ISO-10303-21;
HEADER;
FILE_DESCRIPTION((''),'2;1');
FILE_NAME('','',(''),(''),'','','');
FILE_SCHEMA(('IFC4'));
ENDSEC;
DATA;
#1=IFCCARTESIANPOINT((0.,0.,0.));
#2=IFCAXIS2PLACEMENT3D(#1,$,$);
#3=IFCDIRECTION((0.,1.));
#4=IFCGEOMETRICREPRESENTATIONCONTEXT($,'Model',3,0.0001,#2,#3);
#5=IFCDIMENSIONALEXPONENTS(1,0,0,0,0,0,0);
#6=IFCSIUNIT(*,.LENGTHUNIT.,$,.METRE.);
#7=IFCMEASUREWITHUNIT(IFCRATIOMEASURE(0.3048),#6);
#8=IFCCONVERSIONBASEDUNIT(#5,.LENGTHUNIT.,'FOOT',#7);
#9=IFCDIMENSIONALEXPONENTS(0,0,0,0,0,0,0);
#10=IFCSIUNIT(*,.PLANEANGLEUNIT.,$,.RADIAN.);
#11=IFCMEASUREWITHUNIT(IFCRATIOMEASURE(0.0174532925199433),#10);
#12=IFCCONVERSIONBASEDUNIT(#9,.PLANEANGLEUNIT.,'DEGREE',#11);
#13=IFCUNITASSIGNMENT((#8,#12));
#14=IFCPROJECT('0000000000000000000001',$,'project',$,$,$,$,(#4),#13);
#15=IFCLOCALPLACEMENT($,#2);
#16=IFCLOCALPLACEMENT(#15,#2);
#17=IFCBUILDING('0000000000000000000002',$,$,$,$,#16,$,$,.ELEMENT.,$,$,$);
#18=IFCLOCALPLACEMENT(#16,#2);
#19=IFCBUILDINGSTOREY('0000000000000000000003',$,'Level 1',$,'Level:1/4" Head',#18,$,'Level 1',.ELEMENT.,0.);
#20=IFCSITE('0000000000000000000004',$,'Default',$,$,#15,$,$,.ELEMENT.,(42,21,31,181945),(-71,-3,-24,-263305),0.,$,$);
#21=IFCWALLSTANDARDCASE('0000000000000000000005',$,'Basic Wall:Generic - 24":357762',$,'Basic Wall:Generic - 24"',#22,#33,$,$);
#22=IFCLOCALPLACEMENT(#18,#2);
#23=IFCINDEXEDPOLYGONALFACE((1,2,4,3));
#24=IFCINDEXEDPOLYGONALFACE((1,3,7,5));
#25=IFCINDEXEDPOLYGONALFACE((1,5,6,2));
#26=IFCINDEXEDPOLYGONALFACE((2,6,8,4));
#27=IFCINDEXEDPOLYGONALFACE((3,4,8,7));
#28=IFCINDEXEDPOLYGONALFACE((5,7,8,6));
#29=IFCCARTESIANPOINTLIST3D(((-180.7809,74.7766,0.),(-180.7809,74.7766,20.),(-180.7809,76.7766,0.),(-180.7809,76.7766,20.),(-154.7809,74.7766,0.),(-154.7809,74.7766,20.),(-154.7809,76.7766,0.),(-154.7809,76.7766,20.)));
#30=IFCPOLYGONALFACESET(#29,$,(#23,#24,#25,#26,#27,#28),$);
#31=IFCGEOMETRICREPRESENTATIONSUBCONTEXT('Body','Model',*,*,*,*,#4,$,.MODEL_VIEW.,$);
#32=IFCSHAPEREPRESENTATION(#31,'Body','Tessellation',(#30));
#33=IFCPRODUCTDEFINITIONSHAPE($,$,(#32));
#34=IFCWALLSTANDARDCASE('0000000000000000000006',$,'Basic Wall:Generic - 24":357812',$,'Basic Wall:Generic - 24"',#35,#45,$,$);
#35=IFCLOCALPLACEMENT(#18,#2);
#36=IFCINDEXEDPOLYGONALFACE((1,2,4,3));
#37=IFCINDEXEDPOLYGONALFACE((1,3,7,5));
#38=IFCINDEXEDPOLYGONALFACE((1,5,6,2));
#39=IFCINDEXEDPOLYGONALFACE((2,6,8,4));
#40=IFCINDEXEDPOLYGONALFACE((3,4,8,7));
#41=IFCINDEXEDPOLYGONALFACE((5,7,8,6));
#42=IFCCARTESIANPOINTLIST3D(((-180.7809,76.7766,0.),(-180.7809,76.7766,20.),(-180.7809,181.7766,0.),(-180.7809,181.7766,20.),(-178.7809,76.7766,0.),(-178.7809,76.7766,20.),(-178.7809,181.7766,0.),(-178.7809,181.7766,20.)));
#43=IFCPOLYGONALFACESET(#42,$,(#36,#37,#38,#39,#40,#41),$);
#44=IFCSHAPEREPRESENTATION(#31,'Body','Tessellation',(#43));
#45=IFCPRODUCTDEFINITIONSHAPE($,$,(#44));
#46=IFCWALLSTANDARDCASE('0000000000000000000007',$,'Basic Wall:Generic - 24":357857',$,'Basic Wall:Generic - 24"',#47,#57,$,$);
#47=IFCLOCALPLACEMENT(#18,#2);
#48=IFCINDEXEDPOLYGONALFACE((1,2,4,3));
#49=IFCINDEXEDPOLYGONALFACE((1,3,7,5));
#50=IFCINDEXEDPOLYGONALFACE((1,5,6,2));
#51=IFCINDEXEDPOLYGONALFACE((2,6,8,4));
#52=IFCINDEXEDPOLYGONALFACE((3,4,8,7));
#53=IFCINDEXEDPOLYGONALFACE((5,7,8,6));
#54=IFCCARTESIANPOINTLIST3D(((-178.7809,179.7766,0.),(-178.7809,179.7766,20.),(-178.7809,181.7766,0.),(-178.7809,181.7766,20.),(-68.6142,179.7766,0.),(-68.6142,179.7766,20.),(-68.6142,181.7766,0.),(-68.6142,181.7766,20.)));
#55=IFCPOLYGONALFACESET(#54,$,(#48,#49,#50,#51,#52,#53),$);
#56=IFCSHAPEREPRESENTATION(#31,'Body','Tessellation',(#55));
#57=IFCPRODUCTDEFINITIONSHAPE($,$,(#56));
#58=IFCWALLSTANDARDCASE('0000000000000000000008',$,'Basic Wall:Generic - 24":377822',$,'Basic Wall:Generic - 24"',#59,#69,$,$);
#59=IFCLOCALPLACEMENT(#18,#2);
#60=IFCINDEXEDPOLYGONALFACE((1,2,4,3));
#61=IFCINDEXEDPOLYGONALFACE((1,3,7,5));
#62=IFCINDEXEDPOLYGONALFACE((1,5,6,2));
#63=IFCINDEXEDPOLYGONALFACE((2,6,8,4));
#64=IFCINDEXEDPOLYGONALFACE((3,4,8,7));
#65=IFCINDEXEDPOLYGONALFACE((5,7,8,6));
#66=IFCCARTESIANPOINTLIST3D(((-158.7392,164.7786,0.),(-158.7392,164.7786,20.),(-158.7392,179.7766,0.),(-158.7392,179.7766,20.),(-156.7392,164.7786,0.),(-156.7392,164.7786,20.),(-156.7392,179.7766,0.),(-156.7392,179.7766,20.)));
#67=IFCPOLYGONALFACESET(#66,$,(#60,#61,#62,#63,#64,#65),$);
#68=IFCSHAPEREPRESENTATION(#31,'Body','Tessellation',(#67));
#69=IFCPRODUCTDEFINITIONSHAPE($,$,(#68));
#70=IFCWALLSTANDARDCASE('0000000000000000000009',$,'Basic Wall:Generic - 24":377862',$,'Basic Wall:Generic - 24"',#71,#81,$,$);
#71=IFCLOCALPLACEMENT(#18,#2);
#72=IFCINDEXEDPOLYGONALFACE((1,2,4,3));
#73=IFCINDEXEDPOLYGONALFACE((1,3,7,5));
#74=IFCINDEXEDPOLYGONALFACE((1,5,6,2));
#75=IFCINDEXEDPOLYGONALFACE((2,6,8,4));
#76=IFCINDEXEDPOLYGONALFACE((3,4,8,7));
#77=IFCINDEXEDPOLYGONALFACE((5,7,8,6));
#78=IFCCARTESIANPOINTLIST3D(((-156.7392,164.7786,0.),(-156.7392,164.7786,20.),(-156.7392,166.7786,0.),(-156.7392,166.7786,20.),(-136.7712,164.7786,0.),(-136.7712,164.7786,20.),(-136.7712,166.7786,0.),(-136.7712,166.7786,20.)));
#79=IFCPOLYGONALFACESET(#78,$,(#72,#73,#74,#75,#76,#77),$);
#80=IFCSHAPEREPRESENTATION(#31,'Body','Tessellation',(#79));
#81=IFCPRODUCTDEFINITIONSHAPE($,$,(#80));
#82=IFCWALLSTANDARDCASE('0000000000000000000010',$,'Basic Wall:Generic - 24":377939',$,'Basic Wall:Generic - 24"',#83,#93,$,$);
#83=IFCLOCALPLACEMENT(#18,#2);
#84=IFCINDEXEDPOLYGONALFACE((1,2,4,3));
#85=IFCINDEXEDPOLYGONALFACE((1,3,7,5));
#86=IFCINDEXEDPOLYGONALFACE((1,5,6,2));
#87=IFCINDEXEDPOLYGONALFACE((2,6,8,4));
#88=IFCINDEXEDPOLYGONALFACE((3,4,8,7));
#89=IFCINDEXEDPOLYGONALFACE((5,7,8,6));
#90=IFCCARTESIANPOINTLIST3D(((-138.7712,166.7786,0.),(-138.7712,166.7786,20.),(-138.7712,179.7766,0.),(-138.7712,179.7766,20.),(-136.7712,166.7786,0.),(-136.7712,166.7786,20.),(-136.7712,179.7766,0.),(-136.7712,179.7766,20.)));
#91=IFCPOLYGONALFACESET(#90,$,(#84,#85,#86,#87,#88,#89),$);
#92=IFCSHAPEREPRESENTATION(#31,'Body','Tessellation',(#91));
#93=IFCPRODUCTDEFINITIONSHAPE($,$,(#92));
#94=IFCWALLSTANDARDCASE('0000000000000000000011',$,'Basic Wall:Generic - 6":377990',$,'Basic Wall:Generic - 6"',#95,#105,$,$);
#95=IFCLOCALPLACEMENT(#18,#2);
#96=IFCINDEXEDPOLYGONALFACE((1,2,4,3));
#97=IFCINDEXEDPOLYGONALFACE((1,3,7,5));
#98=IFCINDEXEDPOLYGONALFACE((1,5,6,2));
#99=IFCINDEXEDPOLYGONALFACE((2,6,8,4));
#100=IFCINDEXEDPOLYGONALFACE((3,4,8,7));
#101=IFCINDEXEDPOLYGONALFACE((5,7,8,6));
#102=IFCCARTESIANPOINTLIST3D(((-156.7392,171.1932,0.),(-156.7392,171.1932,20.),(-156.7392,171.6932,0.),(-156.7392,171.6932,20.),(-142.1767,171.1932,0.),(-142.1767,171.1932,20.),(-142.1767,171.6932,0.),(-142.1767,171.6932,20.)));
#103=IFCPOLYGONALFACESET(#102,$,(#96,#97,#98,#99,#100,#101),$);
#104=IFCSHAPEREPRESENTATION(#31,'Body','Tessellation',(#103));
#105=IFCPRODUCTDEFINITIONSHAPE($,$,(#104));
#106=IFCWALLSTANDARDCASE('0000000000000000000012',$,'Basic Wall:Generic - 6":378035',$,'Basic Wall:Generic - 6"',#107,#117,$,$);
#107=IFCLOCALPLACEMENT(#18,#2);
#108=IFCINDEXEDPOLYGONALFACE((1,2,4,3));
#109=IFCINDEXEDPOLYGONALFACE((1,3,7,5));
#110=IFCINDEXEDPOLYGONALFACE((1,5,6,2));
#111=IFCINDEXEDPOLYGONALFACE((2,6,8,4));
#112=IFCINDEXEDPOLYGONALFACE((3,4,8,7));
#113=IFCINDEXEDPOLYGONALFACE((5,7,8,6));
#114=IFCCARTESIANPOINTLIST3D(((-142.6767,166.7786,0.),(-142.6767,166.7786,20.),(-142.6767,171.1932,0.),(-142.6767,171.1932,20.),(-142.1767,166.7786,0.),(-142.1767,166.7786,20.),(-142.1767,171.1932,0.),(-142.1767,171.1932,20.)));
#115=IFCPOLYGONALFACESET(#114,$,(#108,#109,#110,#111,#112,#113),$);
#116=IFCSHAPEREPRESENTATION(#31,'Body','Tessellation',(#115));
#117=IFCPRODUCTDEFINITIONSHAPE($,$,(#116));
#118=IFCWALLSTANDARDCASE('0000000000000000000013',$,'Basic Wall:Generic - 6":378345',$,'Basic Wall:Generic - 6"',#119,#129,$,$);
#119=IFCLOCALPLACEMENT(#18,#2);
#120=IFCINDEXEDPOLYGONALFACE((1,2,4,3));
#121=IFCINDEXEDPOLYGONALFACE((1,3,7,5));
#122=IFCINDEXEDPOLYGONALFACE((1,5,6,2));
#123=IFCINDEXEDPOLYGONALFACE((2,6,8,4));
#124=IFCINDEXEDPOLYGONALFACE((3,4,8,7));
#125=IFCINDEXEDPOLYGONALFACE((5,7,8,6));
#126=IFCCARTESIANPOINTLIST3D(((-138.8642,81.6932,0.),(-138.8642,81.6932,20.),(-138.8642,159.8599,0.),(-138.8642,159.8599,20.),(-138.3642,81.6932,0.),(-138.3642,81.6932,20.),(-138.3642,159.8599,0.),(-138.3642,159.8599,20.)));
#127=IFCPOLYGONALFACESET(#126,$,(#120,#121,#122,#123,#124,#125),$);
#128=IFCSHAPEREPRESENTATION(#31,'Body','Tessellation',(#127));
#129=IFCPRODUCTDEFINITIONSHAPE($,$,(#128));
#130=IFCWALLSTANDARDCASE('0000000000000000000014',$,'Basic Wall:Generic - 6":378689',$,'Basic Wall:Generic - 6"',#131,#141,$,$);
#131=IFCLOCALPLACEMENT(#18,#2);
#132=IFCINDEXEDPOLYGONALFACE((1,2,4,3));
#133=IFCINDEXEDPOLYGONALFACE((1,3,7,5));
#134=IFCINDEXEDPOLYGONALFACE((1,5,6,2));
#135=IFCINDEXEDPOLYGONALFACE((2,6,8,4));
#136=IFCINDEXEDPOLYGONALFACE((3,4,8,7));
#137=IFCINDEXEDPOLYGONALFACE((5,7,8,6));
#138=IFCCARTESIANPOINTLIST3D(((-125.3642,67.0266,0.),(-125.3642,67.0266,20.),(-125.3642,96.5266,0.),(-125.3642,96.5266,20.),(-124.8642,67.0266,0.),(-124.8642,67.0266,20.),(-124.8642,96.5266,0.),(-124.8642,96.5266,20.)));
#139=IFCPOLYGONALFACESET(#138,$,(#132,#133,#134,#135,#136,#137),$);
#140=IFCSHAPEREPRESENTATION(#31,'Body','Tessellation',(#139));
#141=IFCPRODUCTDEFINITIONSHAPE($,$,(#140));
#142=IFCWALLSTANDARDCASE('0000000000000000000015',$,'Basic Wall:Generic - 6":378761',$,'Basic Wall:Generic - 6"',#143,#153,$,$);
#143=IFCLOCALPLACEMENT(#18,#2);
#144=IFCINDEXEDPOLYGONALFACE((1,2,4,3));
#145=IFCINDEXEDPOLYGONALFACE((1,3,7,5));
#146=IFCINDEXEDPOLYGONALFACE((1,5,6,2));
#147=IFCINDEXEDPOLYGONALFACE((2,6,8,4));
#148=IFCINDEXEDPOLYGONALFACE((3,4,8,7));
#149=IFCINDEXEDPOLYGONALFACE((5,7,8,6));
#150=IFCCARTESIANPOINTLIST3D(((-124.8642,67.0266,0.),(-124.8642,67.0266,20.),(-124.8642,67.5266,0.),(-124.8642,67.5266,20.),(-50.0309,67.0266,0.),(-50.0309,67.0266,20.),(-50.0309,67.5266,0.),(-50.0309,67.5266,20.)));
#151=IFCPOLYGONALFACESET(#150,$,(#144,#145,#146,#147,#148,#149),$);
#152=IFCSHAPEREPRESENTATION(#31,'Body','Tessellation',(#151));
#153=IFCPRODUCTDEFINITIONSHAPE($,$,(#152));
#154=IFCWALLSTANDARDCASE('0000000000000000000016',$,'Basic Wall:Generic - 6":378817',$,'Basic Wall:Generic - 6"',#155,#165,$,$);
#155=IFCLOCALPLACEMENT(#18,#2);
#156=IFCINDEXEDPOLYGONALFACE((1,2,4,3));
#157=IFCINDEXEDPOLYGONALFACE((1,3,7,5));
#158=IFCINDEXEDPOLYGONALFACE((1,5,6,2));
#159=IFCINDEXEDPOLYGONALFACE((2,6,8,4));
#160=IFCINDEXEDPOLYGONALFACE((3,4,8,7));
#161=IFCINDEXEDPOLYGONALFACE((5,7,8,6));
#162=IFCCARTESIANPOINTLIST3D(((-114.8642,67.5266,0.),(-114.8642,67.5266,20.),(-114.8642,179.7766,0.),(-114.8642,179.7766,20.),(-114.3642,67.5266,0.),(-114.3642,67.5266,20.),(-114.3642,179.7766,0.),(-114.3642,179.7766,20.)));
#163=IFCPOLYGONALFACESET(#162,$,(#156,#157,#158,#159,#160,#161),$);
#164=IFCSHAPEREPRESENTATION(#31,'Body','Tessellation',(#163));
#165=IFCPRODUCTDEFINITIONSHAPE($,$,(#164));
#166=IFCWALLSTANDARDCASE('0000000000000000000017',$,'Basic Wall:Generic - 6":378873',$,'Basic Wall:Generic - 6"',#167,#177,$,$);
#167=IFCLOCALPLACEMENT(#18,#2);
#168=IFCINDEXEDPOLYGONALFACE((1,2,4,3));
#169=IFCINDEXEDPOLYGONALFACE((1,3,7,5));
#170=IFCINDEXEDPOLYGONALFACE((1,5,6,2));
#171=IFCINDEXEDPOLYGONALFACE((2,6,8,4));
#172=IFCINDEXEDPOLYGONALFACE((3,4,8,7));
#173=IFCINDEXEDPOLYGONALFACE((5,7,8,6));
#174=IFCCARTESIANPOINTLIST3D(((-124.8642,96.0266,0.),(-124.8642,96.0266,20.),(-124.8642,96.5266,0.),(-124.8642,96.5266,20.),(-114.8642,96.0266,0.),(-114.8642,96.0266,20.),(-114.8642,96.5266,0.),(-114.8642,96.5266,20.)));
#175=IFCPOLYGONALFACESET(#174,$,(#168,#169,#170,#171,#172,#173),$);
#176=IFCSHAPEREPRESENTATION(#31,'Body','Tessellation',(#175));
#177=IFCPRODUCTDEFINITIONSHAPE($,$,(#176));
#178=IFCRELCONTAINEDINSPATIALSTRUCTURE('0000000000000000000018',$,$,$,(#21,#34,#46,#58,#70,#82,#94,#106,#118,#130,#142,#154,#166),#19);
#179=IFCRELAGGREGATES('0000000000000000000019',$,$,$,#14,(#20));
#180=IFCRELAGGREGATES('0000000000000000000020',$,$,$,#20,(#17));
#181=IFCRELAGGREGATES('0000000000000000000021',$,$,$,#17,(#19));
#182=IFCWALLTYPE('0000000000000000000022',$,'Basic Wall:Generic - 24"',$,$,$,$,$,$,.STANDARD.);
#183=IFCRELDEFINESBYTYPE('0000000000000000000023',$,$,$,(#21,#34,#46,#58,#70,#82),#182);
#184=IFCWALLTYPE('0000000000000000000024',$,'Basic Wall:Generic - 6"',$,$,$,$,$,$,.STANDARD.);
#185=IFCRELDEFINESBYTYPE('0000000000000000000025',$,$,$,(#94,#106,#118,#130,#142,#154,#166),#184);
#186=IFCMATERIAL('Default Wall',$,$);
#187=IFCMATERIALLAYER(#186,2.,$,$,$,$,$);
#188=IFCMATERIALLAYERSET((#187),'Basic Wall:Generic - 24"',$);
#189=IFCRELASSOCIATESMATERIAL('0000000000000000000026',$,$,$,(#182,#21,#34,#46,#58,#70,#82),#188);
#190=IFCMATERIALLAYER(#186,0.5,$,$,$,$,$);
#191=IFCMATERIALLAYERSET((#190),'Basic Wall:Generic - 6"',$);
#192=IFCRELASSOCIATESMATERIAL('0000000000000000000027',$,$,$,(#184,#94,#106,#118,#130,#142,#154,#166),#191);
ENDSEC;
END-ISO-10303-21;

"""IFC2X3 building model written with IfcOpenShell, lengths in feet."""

from ifc_helpers import new_model, entity, si_unit, converted_unit, direction, frame, frame_2d, origin, place, context, subcontext, project, spatial, rectangle, extrude, material, layer, layer_set, layer_usage, type_object, element, save


model = new_model("IFC2X3")

# Units and contexts
model_context = context("Model", 3, precision=0.0001, world=origin(), true_north=direction((0.0, 1.0)))
body_context = subcontext(model_context, "Body", "Model", "MODEL_VIEW")
ifc_project = project(units=[converted_unit("LENGTHUNIT", "FOOT", entity("IfcRatioMeasure", 0.3048), si_unit("LENGTHUNIT", "METRE"), dimensions=[1, 0, 0, 0, 0, 0, 0]), converted_unit("PLANEANGLEUNIT", "DEGREE", entity("IfcRatioMeasure", 0.0174532925199433), si_unit("PLANEANGLEUNIT", "RADIAN"), dimensions=[0, 0, 0, 0, 0, 0, 0])], contexts=[model_context])

# Site, building, storey
site_placement = place(None, origin())
site = spatial("IfcSite", under=ifc_project, at=site_placement, Name="Default", CompositionType="ELEMENT", RefLatitude=(42, 21, 31, 181945), RefLongitude=(-71, -3, -24, -263305), RefElevation=0.0)
building_placement = place(site_placement, origin())
building = spatial("IfcBuilding", under=site, at=building_placement, CompositionType="ELEMENT")
storey_placement = place(building_placement, origin())
storey = spatial("IfcBuildingStorey", under=building, at=storey_placement, Name="Level 1", ObjectType="Level:1/4\" Head", LongName="Level 1", CompositionType="ELEMENT", Elevation=0.0)

# Walls
ifc_material = material(Name="Default Wall")
ifc_layer_1 = layer(ifc_material, 2.0)
ifc_layer_set_1 = layer_set([ifc_layer_1], Name="Basic Wall:Generic - 24\"")
ifc_layer_usage_1 = layer_usage(ifc_layer_set_1, "AXIS2", "NEGATIVE", 1.0)
wall_type_1 = type_object("IfcWallType", Name="Basic Wall:Generic - 24\"", PredefinedType="STANDARD", material=ifc_layer_set_1)
wall_1_placement = place(storey_placement, frame((-154.7809, 75.7766, 0.0), z_axis=(0.0, 0.0, 1.0), x_axis=(-1.0, 0.0, 0.0)))
element("IfcWallStandardCase", 1, at=wall_1_placement, inside=storey, type_object=wall_type_1, material=ifc_layer_usage_1, Name="Basic Wall:Generic - 24\":357762", ObjectType="Basic Wall:Generic - 24\"", context=body_context, shape_type="SweptSolid", body=[
    extrude(rectangle(XDim=26.0, YDim=2.0, at=frame_2d((13.0, 0.0), x_axis=(-1.0, 0.0))), origin(), (0.0, 0.0, 1.0), 20.0),
])
ifc_layer_usage_2 = layer_usage(ifc_layer_set_1, "AXIS2", "NEGATIVE", 1.0)
wall_2_placement = place(storey_placement, frame((-179.7809, 76.7766, 0.0), z_axis=(0.0, 0.0, 1.0), x_axis=(0.0, 1.0, 0.0)))
element("IfcWallStandardCase", 2, at=wall_2_placement, inside=storey, type_object=wall_type_1, material=ifc_layer_usage_2, Name="Basic Wall:Generic - 24\":357812", ObjectType="Basic Wall:Generic - 24\"", context=body_context, shape_type="SweptSolid", body=[
    extrude(rectangle(XDim=105.0, YDim=2.0, at=frame_2d((52.5, 0.0), x_axis=(-1.0, 0.0))), origin(), (0.0, 0.0, 1.0), 20.0),
])
ifc_layer_usage_3 = layer_usage(ifc_layer_set_1, "AXIS2", "NEGATIVE", 1.0)
wall_3_placement = place(storey_placement, frame((-178.7809, 180.7766, 0.0)))
element("IfcWallStandardCase", 3, at=wall_3_placement, inside=storey, type_object=wall_type_1, material=ifc_layer_usage_3, Name="Basic Wall:Generic - 24\":357857", ObjectType="Basic Wall:Generic - 24\"", context=body_context, shape_type="SweptSolid", body=[
    extrude(rectangle(XDim=110.1667, YDim=2.0, at=frame_2d((55.0833, 0.0), x_axis=(-1.0, 0.0))), origin(), (0.0, 0.0, 1.0), 20.0),
])
ifc_layer_usage_4 = layer_usage(ifc_layer_set_1, "AXIS2", "NEGATIVE", 1.0)
wall_4_placement = place(storey_placement, frame((-157.7392, 179.7766, 0.0), z_axis=(0.0, 0.0, 1.0), x_axis=(0.0, -1.0, 0.0)))
element("IfcWallStandardCase", 4, at=wall_4_placement, inside=storey, type_object=wall_type_1, material=ifc_layer_usage_4, Name="Basic Wall:Generic - 24\":377822", ObjectType="Basic Wall:Generic - 24\"", context=body_context, shape_type="SweptSolid", body=[
    extrude(rectangle(XDim=14.998, YDim=2.0, at=frame_2d((7.499, 0.0), x_axis=(-1.0, 0.0))), origin(), (0.0, 0.0, 1.0), 20.0),
])
ifc_layer_usage_5 = layer_usage(ifc_layer_set_1, "AXIS2", "NEGATIVE", 1.0)
wall_5_placement = place(storey_placement, frame((-156.7392, 165.7786, 0.0)))
element("IfcWallStandardCase", 5, at=wall_5_placement, inside=storey, type_object=wall_type_1, material=ifc_layer_usage_5, Name="Basic Wall:Generic - 24\":377862", ObjectType="Basic Wall:Generic - 24\"", context=body_context, shape_type="SweptSolid", body=[
    extrude(rectangle(XDim=19.968, YDim=2.0, at=frame_2d((9.984, 0.0), x_axis=(-1.0, 0.0))), origin(), (0.0, 0.0, 1.0), 20.0),
])
ifc_layer_usage_6 = layer_usage(ifc_layer_set_1, "AXIS2", "NEGATIVE", 1.0)
wall_6_placement = place(storey_placement, frame((-137.7712, 166.7786, 0.0), z_axis=(0.0, 0.0, 1.0), x_axis=(0.0, 1.0, 0.0)))
element("IfcWallStandardCase", 6, at=wall_6_placement, inside=storey, type_object=wall_type_1, material=ifc_layer_usage_6, Name="Basic Wall:Generic - 24\":377939", ObjectType="Basic Wall:Generic - 24\"", context=body_context, shape_type="SweptSolid", body=[
    extrude(rectangle(XDim=12.998, YDim=2.0, at=frame_2d((6.499, 0.0), x_axis=(-1.0, 0.0))), origin(), (0.0, 0.0, 1.0), 20.0),
])
ifc_layer_2 = layer(ifc_material, 0.5)
ifc_layer_set_2 = layer_set([ifc_layer_2], Name="Basic Wall:Generic - 6\"")
ifc_layer_usage_7 = layer_usage(ifc_layer_set_2, "AXIS2", "NEGATIVE", 0.25)
wall_type_2 = type_object("IfcWallType", Name="Basic Wall:Generic - 6\"", PredefinedType="STANDARD", material=ifc_layer_set_2)
wall_7_placement = place(storey_placement, frame((-156.7392, 171.4432, 0.0)))
element("IfcWallStandardCase", 7, at=wall_7_placement, inside=storey, type_object=wall_type_2, material=ifc_layer_usage_7, Name="Basic Wall:Generic - 6\":377990", ObjectType="Basic Wall:Generic - 6\"", context=body_context, shape_type="SweptSolid", body=[
    extrude(rectangle(XDim=14.5625, YDim=0.5, at=frame_2d((7.2812, 0.0), x_axis=(-1.0, 0.0))), origin(), (0.0, 0.0, 1.0), 20.0),
])
ifc_layer_usage_8 = layer_usage(ifc_layer_set_2, "AXIS2", "NEGATIVE", 0.25)
wall_8_placement = place(storey_placement, frame((-142.4267, 171.1932, 0.0), z_axis=(0.0, 0.0, 1.0), x_axis=(0.0, -1.0, 0.0)))
element("IfcWallStandardCase", 8, at=wall_8_placement, inside=storey, type_object=wall_type_2, material=ifc_layer_usage_8, Name="Basic Wall:Generic - 6\":378035", ObjectType="Basic Wall:Generic - 6\"", context=body_context, shape_type="SweptSolid", body=[
    extrude(rectangle(XDim=4.4146, YDim=0.5, at=frame_2d((2.2073, 0.0), x_axis=(-1.0, 0.0))), origin(), (0.0, 0.0, 1.0), 20.0),
])
ifc_layer_usage_9 = layer_usage(ifc_layer_set_2, "AXIS2", "NEGATIVE", 0.25)
wall_9_placement = place(storey_placement, frame((-138.6142, 159.8599, 0.0), z_axis=(0.0, 0.0, 1.0), x_axis=(0.0, -1.0, 0.0)))
element("IfcWallStandardCase", 9, at=wall_9_placement, inside=storey, type_object=wall_type_2, material=ifc_layer_usage_9, Name="Basic Wall:Generic - 6\":378345", ObjectType="Basic Wall:Generic - 6\"", context=body_context, shape_type="SweptSolid", body=[
    extrude(rectangle(XDim=78.1667, YDim=0.5, at=frame_2d((39.0833, 0.0), x_axis=(-1.0, 0.0))), origin(), (0.0, 0.0, 1.0), 20.0),
])
ifc_layer_usage_10 = layer_usage(ifc_layer_set_2, "AXIS2", "NEGATIVE", 0.25)
wall_10_placement = place(storey_placement, frame((-125.1142, 96.5266, 0.0), z_axis=(0.0, 0.0, 1.0), x_axis=(0.0, -1.0, 0.0)))
element("IfcWallStandardCase", 10, at=wall_10_placement, inside=storey, type_object=wall_type_2, material=ifc_layer_usage_10, Name="Basic Wall:Generic - 6\":378689", ObjectType="Basic Wall:Generic - 6\"", context=body_context, shape_type="SweptSolid", body=[
    extrude(rectangle(XDim=29.5, YDim=0.5, at=frame_2d((14.75, 0.0), x_axis=(-1.0, 0.0))), origin(), (0.0, 0.0, 1.0), 20.0),
])
ifc_layer_usage_11 = layer_usage(ifc_layer_set_2, "AXIS2", "NEGATIVE", 0.25)
wall_11_placement = place(storey_placement, frame((-124.8642, 67.2766, 0.0)))
element("IfcWallStandardCase", 11, at=wall_11_placement, inside=storey, type_object=wall_type_2, material=ifc_layer_usage_11, Name="Basic Wall:Generic - 6\":378761", ObjectType="Basic Wall:Generic - 6\"", context=body_context, shape_type="SweptSolid", body=[
    extrude(rectangle(XDim=74.8333, YDim=0.5, at=frame_2d((37.4167, 0.0), x_axis=(-1.0, 0.0))), origin(), (0.0, 0.0, 1.0), 20.0),
])
ifc_layer_usage_12 = layer_usage(ifc_layer_set_2, "AXIS2", "NEGATIVE", 0.25)
wall_12_placement = place(storey_placement, frame((-114.6142, 67.5266, 0.0), z_axis=(0.0, 0.0, 1.0), x_axis=(0.0, 1.0, 0.0)))
element("IfcWallStandardCase", 12, at=wall_12_placement, inside=storey, type_object=wall_type_2, material=ifc_layer_usage_12, Name="Basic Wall:Generic - 6\":378817", ObjectType="Basic Wall:Generic - 6\"", context=body_context, shape_type="SweptSolid", body=[
    extrude(rectangle(XDim=112.25, YDim=0.5, at=frame_2d((56.125, 0.0), x_axis=(-1.0, 0.0))), origin(), (0.0, 0.0, 1.0), 20.0),
])
ifc_layer_usage_13 = layer_usage(ifc_layer_set_2, "AXIS2", "NEGATIVE", 0.25)
wall_13_placement = place(storey_placement, frame((-114.8642, 96.2766, 0.0), z_axis=(0.0, 0.0, 1.0), x_axis=(-1.0, 0.0, 0.0)))
element("IfcWallStandardCase", 13, at=wall_13_placement, inside=storey, type_object=wall_type_2, material=ifc_layer_usage_13, Name="Basic Wall:Generic - 6\":378873", ObjectType="Basic Wall:Generic - 6\"", context=body_context, shape_type="SweptSolid", body=[
    extrude(rectangle(XDim=10.0, YDim=0.5, at=frame_2d((5.0, 0.0), x_axis=(-1.0, 0.0))), origin(), (0.0, 0.0, 1.0), 20.0),
])

save(model, "model.ifc")
